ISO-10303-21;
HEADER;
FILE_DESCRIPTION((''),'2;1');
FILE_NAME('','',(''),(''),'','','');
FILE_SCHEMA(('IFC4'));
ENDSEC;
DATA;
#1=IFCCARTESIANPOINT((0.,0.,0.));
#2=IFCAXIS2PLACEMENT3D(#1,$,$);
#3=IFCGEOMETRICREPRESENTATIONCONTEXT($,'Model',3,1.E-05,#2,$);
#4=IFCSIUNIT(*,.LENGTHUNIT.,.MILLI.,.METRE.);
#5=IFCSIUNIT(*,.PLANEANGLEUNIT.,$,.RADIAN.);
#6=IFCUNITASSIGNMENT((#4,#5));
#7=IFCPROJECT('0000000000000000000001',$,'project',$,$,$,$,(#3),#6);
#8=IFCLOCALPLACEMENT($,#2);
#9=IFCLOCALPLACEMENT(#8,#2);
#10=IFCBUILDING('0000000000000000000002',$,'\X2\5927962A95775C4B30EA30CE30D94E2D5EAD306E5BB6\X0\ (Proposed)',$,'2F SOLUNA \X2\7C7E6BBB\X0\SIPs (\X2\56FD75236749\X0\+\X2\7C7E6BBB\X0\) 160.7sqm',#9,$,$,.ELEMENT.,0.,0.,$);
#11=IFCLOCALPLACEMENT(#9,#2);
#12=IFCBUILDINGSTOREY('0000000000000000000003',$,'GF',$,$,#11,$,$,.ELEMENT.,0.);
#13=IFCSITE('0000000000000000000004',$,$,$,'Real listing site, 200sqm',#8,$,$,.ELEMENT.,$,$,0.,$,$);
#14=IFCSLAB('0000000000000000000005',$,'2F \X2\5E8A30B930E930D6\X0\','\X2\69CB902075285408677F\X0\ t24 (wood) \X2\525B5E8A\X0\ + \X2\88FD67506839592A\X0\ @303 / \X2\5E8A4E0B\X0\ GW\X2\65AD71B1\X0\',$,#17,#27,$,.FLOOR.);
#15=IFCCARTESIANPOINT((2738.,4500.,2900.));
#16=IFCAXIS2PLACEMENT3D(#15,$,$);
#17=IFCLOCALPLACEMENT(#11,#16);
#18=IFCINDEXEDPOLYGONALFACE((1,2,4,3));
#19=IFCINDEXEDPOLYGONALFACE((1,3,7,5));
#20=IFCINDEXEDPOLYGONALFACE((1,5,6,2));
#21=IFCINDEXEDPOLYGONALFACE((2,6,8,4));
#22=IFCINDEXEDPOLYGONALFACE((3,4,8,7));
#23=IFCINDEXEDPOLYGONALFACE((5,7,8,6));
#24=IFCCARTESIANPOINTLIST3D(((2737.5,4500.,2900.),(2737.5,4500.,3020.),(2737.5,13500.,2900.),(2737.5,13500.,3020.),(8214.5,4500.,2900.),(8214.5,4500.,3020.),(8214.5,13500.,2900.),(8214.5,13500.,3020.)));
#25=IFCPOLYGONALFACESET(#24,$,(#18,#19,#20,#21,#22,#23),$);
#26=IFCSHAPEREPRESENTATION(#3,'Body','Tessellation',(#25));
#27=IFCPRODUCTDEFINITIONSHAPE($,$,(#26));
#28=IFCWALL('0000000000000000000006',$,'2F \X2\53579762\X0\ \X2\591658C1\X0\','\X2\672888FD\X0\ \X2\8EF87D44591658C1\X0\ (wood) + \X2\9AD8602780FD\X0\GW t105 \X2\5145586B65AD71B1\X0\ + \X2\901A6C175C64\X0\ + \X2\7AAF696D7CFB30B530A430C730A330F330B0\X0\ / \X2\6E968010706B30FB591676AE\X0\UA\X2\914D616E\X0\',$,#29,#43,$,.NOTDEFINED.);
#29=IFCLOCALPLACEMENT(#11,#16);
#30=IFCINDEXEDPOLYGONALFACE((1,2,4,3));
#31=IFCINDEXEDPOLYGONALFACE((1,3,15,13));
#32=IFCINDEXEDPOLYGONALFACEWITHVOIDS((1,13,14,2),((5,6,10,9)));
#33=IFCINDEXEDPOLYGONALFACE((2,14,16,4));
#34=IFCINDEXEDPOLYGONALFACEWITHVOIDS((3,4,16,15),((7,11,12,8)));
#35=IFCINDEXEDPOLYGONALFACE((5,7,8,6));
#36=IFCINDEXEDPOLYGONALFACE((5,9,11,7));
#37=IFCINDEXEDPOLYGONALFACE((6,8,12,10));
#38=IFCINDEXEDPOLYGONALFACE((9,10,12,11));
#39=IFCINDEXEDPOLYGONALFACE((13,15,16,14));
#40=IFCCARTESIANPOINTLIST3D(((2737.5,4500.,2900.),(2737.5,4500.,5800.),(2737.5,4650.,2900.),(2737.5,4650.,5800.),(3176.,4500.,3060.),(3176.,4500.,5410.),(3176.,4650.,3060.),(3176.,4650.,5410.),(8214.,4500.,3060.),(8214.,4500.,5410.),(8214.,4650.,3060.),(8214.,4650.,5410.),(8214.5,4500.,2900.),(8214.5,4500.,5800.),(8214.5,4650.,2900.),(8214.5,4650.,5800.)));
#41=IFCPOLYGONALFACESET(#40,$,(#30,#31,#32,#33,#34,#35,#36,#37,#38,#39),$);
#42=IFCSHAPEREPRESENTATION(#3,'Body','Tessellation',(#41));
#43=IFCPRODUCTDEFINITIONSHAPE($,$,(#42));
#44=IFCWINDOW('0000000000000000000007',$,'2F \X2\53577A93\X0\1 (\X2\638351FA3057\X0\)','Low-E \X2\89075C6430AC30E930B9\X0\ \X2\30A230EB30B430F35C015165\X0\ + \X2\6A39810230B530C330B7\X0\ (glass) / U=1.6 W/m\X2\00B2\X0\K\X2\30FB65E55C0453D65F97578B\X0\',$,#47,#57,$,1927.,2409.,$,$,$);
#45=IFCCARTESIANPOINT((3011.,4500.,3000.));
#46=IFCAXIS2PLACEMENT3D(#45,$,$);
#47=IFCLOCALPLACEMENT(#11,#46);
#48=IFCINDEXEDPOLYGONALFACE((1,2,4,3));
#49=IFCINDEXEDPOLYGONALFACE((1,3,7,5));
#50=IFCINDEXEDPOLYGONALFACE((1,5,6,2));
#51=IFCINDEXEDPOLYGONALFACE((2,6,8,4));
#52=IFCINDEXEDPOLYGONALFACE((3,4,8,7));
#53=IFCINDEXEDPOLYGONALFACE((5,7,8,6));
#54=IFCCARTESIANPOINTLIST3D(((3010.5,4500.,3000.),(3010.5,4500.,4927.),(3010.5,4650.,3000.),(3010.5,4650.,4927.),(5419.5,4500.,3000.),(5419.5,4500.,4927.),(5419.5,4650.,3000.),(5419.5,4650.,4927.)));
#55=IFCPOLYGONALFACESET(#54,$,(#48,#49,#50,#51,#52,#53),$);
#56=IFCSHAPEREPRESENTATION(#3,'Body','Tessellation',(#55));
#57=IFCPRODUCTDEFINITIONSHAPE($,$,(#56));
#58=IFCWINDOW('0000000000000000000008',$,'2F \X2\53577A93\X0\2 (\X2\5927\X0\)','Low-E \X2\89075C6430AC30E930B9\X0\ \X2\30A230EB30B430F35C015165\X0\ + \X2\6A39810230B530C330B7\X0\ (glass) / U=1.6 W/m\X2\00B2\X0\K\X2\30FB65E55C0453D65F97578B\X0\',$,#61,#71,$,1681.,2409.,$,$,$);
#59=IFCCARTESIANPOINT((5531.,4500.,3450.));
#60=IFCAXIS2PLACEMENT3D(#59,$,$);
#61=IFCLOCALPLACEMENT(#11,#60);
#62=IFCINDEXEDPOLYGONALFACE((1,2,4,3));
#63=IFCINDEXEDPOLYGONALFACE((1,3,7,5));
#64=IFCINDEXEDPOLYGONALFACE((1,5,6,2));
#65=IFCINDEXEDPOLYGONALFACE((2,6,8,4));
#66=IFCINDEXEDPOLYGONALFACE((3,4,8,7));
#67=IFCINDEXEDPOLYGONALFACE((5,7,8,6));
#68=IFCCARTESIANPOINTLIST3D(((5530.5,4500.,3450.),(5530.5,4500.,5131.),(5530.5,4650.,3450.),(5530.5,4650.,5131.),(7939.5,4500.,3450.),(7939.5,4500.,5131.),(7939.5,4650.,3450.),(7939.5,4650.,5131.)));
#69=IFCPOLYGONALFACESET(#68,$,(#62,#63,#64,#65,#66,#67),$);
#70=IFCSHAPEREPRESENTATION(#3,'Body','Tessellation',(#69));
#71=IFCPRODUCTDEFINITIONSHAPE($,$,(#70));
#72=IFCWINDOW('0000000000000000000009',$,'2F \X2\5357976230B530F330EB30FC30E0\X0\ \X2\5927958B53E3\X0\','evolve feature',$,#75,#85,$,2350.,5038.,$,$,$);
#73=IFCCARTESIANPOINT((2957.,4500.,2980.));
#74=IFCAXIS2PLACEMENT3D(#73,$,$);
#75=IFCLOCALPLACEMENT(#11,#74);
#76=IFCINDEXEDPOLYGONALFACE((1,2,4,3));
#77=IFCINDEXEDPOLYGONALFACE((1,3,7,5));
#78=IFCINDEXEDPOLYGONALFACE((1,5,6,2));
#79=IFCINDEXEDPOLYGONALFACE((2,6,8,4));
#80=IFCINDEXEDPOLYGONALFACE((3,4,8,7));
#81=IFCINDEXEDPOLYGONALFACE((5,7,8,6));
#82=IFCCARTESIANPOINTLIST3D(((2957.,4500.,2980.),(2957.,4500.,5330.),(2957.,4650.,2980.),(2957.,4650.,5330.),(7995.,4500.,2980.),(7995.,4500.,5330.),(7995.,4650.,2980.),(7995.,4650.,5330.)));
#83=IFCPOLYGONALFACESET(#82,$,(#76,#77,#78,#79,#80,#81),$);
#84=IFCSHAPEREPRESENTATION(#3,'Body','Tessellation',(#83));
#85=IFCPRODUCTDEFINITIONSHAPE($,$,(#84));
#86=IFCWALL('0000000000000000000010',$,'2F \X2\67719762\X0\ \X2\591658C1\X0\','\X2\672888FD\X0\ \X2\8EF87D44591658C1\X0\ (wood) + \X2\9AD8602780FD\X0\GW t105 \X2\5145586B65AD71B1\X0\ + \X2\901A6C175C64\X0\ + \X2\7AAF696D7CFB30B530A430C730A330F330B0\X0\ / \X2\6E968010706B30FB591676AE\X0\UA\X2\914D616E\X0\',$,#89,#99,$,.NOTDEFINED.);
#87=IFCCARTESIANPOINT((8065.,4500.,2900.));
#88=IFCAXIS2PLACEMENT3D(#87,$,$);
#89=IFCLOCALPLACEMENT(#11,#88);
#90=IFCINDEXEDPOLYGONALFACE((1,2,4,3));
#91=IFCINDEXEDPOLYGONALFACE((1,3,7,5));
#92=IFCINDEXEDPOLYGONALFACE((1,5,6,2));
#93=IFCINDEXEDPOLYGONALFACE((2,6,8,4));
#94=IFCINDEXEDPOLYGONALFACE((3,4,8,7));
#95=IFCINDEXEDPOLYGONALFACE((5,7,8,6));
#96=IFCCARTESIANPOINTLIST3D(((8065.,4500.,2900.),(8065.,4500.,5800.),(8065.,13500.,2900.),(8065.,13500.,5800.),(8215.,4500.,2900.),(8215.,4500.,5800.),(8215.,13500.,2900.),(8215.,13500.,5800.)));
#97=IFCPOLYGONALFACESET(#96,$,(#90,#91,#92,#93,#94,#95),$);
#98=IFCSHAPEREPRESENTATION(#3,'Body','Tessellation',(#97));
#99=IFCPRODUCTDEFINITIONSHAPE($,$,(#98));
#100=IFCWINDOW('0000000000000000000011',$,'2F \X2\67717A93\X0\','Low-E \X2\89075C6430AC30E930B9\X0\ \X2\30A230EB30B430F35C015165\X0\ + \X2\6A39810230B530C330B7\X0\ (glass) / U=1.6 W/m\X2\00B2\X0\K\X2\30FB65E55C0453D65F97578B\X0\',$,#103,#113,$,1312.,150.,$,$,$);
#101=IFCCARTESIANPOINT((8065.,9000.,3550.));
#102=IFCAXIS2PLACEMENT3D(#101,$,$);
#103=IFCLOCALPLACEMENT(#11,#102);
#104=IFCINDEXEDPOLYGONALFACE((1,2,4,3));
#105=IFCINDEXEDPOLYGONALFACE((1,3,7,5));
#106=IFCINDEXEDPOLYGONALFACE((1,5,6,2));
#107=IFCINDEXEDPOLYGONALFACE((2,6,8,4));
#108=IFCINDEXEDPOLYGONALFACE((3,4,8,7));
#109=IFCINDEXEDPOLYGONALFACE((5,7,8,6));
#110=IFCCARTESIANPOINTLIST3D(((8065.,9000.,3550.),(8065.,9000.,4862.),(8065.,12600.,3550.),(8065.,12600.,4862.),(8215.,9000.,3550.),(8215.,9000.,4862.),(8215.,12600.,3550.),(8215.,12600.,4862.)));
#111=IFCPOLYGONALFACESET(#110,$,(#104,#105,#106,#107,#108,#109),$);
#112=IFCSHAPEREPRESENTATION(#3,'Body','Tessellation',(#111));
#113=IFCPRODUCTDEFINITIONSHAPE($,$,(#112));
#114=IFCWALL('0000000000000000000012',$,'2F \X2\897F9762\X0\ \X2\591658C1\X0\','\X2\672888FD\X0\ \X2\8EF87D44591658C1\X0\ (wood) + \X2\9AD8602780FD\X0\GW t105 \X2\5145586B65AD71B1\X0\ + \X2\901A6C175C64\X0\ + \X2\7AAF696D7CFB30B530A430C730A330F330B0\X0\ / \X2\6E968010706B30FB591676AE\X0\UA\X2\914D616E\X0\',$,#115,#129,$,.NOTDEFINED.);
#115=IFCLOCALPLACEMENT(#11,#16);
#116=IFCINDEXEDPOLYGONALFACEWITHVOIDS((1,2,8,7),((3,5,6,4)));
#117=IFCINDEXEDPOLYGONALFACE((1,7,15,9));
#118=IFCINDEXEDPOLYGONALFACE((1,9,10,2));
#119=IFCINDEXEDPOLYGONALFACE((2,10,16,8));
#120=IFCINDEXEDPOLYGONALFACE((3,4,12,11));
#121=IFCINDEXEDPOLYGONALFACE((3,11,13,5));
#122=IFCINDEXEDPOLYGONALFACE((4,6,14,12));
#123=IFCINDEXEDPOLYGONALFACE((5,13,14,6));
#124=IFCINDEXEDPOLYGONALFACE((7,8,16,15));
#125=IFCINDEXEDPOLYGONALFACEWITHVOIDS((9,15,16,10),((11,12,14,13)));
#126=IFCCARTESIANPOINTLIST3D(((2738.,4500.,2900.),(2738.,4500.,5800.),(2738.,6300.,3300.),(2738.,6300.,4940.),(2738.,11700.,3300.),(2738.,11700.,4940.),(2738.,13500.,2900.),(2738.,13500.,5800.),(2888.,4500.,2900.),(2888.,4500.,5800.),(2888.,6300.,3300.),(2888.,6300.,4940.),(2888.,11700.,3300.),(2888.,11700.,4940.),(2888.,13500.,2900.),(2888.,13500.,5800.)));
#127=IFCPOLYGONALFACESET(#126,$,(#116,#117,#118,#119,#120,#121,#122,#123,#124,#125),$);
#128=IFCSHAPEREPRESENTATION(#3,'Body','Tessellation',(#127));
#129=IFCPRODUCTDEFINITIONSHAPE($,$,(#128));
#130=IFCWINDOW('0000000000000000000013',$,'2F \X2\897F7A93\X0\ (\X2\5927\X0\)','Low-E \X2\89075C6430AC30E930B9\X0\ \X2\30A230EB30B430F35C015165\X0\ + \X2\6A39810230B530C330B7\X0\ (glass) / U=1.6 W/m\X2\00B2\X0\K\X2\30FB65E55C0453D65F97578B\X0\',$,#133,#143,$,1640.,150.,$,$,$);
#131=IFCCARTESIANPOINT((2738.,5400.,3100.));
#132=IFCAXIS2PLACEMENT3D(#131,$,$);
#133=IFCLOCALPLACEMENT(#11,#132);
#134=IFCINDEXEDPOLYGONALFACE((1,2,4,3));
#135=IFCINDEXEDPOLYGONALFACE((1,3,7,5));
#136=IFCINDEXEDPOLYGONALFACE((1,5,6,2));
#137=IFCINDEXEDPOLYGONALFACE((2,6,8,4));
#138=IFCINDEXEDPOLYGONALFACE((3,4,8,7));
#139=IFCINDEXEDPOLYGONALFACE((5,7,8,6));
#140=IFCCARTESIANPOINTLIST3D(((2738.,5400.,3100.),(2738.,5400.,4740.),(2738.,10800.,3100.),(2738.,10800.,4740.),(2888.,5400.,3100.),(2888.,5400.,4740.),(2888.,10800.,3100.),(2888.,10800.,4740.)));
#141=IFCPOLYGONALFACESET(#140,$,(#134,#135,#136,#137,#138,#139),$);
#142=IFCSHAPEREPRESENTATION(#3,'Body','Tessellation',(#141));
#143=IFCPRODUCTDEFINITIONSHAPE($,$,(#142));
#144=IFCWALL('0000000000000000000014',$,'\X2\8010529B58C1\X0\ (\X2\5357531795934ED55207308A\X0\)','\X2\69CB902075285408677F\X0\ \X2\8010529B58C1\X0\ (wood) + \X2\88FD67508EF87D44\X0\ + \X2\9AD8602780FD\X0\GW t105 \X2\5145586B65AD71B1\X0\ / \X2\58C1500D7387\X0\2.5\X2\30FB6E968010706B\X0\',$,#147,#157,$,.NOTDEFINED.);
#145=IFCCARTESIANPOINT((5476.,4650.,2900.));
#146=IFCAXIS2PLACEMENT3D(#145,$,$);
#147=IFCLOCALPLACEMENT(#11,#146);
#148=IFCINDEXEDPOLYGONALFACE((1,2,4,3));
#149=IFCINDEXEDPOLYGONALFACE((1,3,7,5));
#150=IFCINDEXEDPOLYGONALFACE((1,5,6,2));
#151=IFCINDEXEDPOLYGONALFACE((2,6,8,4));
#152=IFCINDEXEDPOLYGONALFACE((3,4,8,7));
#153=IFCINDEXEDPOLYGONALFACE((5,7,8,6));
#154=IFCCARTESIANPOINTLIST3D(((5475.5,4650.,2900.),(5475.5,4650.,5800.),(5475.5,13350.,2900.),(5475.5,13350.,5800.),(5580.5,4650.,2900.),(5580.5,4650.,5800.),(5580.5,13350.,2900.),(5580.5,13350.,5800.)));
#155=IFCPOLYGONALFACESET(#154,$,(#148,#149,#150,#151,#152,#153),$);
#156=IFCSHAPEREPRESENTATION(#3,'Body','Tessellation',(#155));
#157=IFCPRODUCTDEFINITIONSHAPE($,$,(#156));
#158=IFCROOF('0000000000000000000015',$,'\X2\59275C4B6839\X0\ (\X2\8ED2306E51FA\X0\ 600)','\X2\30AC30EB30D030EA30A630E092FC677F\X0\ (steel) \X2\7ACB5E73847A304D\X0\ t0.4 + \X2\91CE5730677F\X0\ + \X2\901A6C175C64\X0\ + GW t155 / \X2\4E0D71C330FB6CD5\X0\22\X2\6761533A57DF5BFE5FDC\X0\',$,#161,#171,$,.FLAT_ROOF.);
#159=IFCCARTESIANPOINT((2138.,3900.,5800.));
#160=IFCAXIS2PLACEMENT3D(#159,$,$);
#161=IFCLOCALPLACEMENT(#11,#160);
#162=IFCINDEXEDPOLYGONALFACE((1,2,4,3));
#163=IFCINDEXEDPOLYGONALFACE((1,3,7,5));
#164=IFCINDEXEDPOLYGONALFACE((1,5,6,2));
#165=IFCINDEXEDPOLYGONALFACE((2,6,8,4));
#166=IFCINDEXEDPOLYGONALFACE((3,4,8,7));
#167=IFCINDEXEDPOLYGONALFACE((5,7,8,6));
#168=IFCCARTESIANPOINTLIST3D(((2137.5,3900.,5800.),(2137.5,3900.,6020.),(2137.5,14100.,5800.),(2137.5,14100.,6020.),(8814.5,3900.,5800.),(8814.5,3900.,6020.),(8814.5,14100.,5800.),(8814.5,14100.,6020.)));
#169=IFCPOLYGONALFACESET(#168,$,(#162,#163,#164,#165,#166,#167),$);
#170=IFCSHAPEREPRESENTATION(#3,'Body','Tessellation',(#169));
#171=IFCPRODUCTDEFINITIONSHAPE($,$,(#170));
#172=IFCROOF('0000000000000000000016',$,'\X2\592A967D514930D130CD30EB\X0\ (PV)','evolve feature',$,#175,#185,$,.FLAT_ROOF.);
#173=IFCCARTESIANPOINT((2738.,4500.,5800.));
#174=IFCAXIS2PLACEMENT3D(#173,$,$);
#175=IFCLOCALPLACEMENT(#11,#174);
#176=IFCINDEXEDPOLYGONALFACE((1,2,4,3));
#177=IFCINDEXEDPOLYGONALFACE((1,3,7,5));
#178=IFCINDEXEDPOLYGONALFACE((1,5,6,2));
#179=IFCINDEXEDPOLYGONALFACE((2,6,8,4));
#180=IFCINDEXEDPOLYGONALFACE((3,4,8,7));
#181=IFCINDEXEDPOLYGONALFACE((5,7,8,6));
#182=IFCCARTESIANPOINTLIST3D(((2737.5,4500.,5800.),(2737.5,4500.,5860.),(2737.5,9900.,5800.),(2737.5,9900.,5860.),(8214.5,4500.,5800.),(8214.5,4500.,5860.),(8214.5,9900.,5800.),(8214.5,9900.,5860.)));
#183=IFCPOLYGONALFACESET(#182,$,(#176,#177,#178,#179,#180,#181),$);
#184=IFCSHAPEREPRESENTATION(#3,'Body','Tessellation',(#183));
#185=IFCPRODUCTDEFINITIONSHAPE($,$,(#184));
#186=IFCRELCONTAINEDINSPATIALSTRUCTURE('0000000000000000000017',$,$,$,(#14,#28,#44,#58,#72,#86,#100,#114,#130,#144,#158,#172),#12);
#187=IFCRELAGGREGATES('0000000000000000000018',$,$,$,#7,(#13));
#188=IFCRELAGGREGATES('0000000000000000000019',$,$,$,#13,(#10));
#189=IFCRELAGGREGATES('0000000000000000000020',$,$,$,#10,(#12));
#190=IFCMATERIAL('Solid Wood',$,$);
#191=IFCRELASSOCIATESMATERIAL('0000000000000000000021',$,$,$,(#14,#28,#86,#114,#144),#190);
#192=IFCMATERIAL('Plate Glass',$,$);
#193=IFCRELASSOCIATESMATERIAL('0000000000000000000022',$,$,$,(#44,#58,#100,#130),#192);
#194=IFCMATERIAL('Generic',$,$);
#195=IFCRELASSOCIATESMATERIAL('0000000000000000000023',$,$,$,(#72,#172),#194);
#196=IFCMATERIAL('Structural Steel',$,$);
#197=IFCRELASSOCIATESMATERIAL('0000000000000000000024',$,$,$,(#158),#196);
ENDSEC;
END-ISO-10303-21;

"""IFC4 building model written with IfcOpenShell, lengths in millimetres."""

from ifc_helpers import new_model, si_unit, frame, frame_2d, origin, place, context, project, spatial, rectangle, extrude, material, element, fill, save


model = new_model("IFC4")

# Units and contexts
model_context = context("Model", 3, precision=1e-05, world=origin())
ifc_project = project(units=[si_unit("LENGTHUNIT", "METRE", prefix="MILLI"), si_unit("PLANEANGLEUNIT", "RADIAN")], contexts=[model_context])

# Site, building, storey
site_placement = place(None, origin())
site = spatial("IfcSite", under=ifc_project, at=site_placement, ObjectType="Real listing site, 200sqm", CompositionType="ELEMENT", RefElevation=0.0)
building_placement = place(site_placement, origin())
building = spatial("IfcBuilding", under=site, at=building_placement, Name="大阪長屋リノベ中庭の家 (Proposed)", ObjectType="2F SOLUNA 籾殻SIPs (国産杉+籾殻) 160.7sqm", CompositionType="ELEMENT", ElevationOfRefHeight=0.0, ElevationOfTerrain=0.0)
storey_placement = place(building_placement, origin())
storey = spatial("IfcBuildingStorey", under=building, at=storey_placement, Name="GF", CompositionType="ELEMENT", Elevation=0.0)

# Slab
ifc_material_1 = material(Name="Solid Wood")
slab_placement = place(storey_placement, frame((2738.0, 4500.0, 2900.0)))
element("IfcSlab", 1, at=slab_placement, inside=storey, material=ifc_material_1, Name="2F 床スラブ", Description="構造用合板 t24 (wood) 剛床 + 製材根太 @303 / 床下 GW断熱", PredefinedType="FLOOR", context=model_context, shape_type="SweptSolid", body=[
    extrude(rectangle(XDim=5477.0, YDim=9000.0, at=frame_2d((2738.0, 4500.0))), frame((2738.0, 4500.0, 2900.0)), (0.0, 0.0, 1.0), 120.0),
])

# Wall, openings, windows
wall_1_placement = place(storey_placement, frame((2738.0, 4500.0, 2900.0)))
wall_1 = element("IfcWall", 2, at=wall_1_placement, inside=storey, material=ifc_material_1, Name="2F 南面 外壁", Description="木製 軸組外壁 (wood) + 高性能GW t105 充填断熱 + 通気層 + 窯業系サイディング / 準耐火・外皮UA配慮", PredefinedType="NOTDEFINED", context=model_context, shape_type="SweptSolid", body=[
    extrude(rectangle(XDim=5477.0, YDim=150.0, at=frame_2d((2738.0, 75.0))), frame((2738.0, 4500.0, 2900.0)), (0.0, 0.0, 1.0), 2900.0),
])
opening_1_placement = place(storey_placement, frame((3011.0, 4500.0, 3000.0)))
opening_1 = element("IfcOpeningElement", 3, at=opening_1_placement, cuts=wall_1, PredefinedType="NOTDEFINED", context=model_context, shape_type="SweptSolid", body=[
    extrude(rectangle(XDim=2409.0, YDim=150.0, at=frame_2d((1204.0, 75.0))), frame((3011.0, 4500.0, 3000.0)), (0.0, 0.0, 1.0), 1927.0),
])
opening_2_placement = place(storey_placement, frame((5531.0, 4500.0, 3450.0)))
opening_2 = element("IfcOpeningElement", 4, at=opening_2_placement, cuts=wall_1, PredefinedType="NOTDEFINED", context=model_context, shape_type="SweptSolid", body=[
    extrude(rectangle(XDim=2409.0, YDim=150.0, at=frame_2d((1204.0, 75.0))), frame((5531.0, 4500.0, 3450.0)), (0.0, 0.0, 1.0), 1681.0),
])
opening_3_placement = place(storey_placement, frame((2957.0, 4500.0, 2980.0)))
opening_3 = element("IfcOpeningElement", 5, at=opening_3_placement, cuts=wall_1, PredefinedType="NOTDEFINED", context=model_context, shape_type="SweptSolid", body=[
    extrude(rectangle(XDim=5038.0, YDim=150.0, at=frame_2d((2519.0, 75.0))), frame((2957.0, 4500.0, 2980.0)), (0.0, 0.0, 1.0), 2350.0),
])
ifc_material_2 = material(Name="Plate Glass")
window_1_placement = place(storey_placement, frame((3011.0, 4500.0, 3000.0)))
window_1 = element("IfcWindow", 6, at=window_1_placement, inside=storey, material=ifc_material_2, Name="2F 南窓1 (掃出し)", Description="Low-E 複層ガラス アルゴン封入 + 樹脂サッシ (glass) / U=1.6 W/m²K・日射取得型", OverallHeight=1927.0, OverallWidth=2409.0, context=model_context, shape_type="SweptSolid", body=[
    extrude(rectangle(XDim=2409.0, YDim=150.0, at=frame_2d((1204.0, 75.0))), frame((3011.0, 4500.0, 3000.0)), (0.0, 0.0, 1.0), 1927.0),
])
fill(opening_1, window_1)
window_2_placement = place(storey_placement, frame((5531.0, 4500.0, 3450.0)))
window_2 = element("IfcWindow", 7, at=window_2_placement, inside=storey, material=ifc_material_2, Name="2F 南窓2 (大)", Description="Low-E 複層ガラス アルゴン封入 + 樹脂サッシ (glass) / U=1.6 W/m²K・日射取得型", OverallHeight=1681.0, OverallWidth=2409.0, context=model_context, shape_type="SweptSolid", body=[
    extrude(rectangle(XDim=2409.0, YDim=150.0, at=frame_2d((1204.0, 75.0))), frame((5531.0, 4500.0, 3450.0)), (0.0, 0.0, 1.0), 1681.0),
])
fill(opening_2, window_2)
ifc_material_3 = material(Name="Generic")
window_3_placement = place(storey_placement, frame((2957.0, 4500.0, 2980.0)))
window_3 = element("IfcWindow", 8, at=window_3_placement, inside=storey, material=ifc_material_3, Name="2F 南面サンルーム 大開口", Description="evolve feature", OverallHeight=2350.0, OverallWidth=5038.0, context=model_context, shape_type="SweptSolid", body=[
    extrude(rectangle(XDim=5038.0, YDim=150.0, at=frame_2d((2519.0, 75.0))), frame((2957.0, 4500.0, 2980.0)), (0.0, 0.0, 1.0), 2350.0),
])
fill(opening_3, window_3)

# Walls, openings, windows
wall_2_placement = place(storey_placement, frame((8065.0, 4500.0, 2900.0)))
wall_2 = element("IfcWall", 9, at=wall_2_placement, inside=storey, material=ifc_material_1, Name="2F 東面 外壁", Description="木製 軸組外壁 (wood) + 高性能GW t105 充填断熱 + 通気層 + 窯業系サイディング / 準耐火・外皮UA配慮", PredefinedType="NOTDEFINED", context=model_context, shape_type="SweptSolid", body=[
    extrude(rectangle(XDim=150.0, YDim=9000.0, at=frame_2d((75.0, 4500.0))), frame((8065.0, 4500.0, 2900.0)), (0.0, 0.0, 1.0), 2900.0),
])
opening_4_placement = place(storey_placement, frame((8065.0, 9000.0, 3550.0)))
opening_4 = element("IfcOpeningElement", 10, at=opening_4_placement, cuts=wall_2, PredefinedType="NOTDEFINED", context=model_context, shape_type="SweptSolid", body=[
    extrude(rectangle(XDim=150.0, YDim=3600.0, at=frame_2d((75.0, 1800.0))), frame((8065.0, 9000.0, 3550.0)), (0.0, 0.0, 1.0), 1312.0),
])
window_4_placement = place(storey_placement, frame((8065.0, 9000.0, 3550.0)))
window_4 = element("IfcWindow", 11, at=window_4_placement, inside=storey, material=ifc_material_2, Name="2F 東窓", Description="Low-E 複層ガラス アルゴン封入 + 樹脂サッシ (glass) / U=1.6 W/m²K・日射取得型", OverallHeight=1312.0, OverallWidth=150.0, context=model_context, shape_type="SweptSolid", body=[
    extrude(rectangle(XDim=150.0, YDim=3600.0, at=frame_2d((75.0, 1800.0))), frame((8065.0, 9000.0, 3550.0)), (0.0, 0.0, 1.0), 1312.0),
])
fill(opening_4, window_4)
wall_3_placement = place(storey_placement, frame((2738.0, 4500.0, 2900.0)))
wall_3 = element("IfcWall", 12, at=wall_3_placement, inside=storey, material=ifc_material_1, Name="2F 西面 外壁", Description="木製 軸組外壁 (wood) + 高性能GW t105 充填断熱 + 通気層 + 窯業系サイディング / 準耐火・外皮UA配慮", PredefinedType="NOTDEFINED", context=model_context, shape_type="SweptSolid", body=[
    extrude(rectangle(XDim=150.0, YDim=9000.0, at=frame_2d((75.0, 4500.0))), frame((2738.0, 4500.0, 2900.0)), (0.0, 0.0, 1.0), 2900.0),
])
opening_5_placement = place(storey_placement, frame((2738.0, 5400.0, 3100.0)))
opening_5 = element("IfcOpeningElement", 13, at=opening_5_placement, cuts=wall_3, PredefinedType="NOTDEFINED", context=model_context, shape_type="SweptSolid", body=[
    extrude(rectangle(XDim=150.0, YDim=5400.0, at=frame_2d((75.0, 2700.0))), frame((2738.0, 5400.0, 3100.0)), (0.0, 0.0, 1.0), 1640.0),
])
window_5_placement = place(storey_placement, frame((2738.0, 5400.0, 3100.0)))
window_5 = element("IfcWindow", 14, at=window_5_placement, inside=storey, material=ifc_material_2, Name="2F 西窓 (大)", Description="Low-E 複層ガラス アルゴン封入 + 樹脂サッシ (glass) / U=1.6 W/m²K・日射取得型", OverallHeight=1640.0, OverallWidth=150.0, context=model_context, shape_type="SweptSolid", body=[
    extrude(rectangle(XDim=150.0, YDim=5400.0, at=frame_2d((75.0, 2700.0))), frame((2738.0, 5400.0, 3100.0)), (0.0, 0.0, 1.0), 1640.0),
])
fill(opening_5, window_5)

# Wall
wall_4_placement = place(storey_placement, frame((5476.0, 4650.0, 2900.0)))
element("IfcWall", 15, at=wall_4_placement, inside=storey, material=ifc_material_1, Name="耐力壁 (南北間仕切り)", Description="構造用合板 耐力壁 (wood) + 製材軸組 + 高性能GW t105 充填断熱 / 壁倍率2.5・準耐火", PredefinedType="NOTDEFINED", context=model_context, shape_type="SweptSolid", body=[
    extrude(rectangle(XDim=105.0, YDim=8700.0, at=frame_2d((52.0, 4350.0))), frame((5476.0, 4650.0, 2900.0)), (0.0, 0.0, 1.0), 2900.0),
])

# Roofs
ifc_material_4 = material(Name="Structural Steel")
roof_1_placement = place(storey_placement, frame((2138.0, 3900.0, 5800.0)))
element("IfcRoof", 16, at=roof_1_placement, inside=storey, material=ifc_material_4, Name="大屋根 (軒の出 600)", Description="ガルバリウム鋼板 (steel) 立平葺き t0.4 + 野地板 + 通気層 + GW t155 / 不燃・法22条区域対応", PredefinedType="FLAT_ROOF", context=model_context, shape_type="SweptSolid", body=[
    extrude(rectangle(XDim=6677.0, YDim=10200.0, at=frame_2d((3338.0, 5100.0))), frame((2138.0, 3900.0, 5800.0)), (0.0, 0.0, 1.0), 220.0),
])
roof_2_placement = place(storey_placement, frame((2738.0, 4500.0, 5800.0)))
element("IfcRoof", 17, at=roof_2_placement, inside=storey, material=ifc_material_3, Name="太陽光パネル (PV)", Description="evolve feature", PredefinedType="FLAT_ROOF", context=model_context, shape_type="SweptSolid", body=[
    extrude(rectangle(XDim=5477.0, YDim=5400.0, at=frame_2d((2738.0, 2700.0))), frame((2738.0, 4500.0, 5800.0)), (0.0, 0.0, 1.0), 60.0),
])

save(model, "model.ifc")
